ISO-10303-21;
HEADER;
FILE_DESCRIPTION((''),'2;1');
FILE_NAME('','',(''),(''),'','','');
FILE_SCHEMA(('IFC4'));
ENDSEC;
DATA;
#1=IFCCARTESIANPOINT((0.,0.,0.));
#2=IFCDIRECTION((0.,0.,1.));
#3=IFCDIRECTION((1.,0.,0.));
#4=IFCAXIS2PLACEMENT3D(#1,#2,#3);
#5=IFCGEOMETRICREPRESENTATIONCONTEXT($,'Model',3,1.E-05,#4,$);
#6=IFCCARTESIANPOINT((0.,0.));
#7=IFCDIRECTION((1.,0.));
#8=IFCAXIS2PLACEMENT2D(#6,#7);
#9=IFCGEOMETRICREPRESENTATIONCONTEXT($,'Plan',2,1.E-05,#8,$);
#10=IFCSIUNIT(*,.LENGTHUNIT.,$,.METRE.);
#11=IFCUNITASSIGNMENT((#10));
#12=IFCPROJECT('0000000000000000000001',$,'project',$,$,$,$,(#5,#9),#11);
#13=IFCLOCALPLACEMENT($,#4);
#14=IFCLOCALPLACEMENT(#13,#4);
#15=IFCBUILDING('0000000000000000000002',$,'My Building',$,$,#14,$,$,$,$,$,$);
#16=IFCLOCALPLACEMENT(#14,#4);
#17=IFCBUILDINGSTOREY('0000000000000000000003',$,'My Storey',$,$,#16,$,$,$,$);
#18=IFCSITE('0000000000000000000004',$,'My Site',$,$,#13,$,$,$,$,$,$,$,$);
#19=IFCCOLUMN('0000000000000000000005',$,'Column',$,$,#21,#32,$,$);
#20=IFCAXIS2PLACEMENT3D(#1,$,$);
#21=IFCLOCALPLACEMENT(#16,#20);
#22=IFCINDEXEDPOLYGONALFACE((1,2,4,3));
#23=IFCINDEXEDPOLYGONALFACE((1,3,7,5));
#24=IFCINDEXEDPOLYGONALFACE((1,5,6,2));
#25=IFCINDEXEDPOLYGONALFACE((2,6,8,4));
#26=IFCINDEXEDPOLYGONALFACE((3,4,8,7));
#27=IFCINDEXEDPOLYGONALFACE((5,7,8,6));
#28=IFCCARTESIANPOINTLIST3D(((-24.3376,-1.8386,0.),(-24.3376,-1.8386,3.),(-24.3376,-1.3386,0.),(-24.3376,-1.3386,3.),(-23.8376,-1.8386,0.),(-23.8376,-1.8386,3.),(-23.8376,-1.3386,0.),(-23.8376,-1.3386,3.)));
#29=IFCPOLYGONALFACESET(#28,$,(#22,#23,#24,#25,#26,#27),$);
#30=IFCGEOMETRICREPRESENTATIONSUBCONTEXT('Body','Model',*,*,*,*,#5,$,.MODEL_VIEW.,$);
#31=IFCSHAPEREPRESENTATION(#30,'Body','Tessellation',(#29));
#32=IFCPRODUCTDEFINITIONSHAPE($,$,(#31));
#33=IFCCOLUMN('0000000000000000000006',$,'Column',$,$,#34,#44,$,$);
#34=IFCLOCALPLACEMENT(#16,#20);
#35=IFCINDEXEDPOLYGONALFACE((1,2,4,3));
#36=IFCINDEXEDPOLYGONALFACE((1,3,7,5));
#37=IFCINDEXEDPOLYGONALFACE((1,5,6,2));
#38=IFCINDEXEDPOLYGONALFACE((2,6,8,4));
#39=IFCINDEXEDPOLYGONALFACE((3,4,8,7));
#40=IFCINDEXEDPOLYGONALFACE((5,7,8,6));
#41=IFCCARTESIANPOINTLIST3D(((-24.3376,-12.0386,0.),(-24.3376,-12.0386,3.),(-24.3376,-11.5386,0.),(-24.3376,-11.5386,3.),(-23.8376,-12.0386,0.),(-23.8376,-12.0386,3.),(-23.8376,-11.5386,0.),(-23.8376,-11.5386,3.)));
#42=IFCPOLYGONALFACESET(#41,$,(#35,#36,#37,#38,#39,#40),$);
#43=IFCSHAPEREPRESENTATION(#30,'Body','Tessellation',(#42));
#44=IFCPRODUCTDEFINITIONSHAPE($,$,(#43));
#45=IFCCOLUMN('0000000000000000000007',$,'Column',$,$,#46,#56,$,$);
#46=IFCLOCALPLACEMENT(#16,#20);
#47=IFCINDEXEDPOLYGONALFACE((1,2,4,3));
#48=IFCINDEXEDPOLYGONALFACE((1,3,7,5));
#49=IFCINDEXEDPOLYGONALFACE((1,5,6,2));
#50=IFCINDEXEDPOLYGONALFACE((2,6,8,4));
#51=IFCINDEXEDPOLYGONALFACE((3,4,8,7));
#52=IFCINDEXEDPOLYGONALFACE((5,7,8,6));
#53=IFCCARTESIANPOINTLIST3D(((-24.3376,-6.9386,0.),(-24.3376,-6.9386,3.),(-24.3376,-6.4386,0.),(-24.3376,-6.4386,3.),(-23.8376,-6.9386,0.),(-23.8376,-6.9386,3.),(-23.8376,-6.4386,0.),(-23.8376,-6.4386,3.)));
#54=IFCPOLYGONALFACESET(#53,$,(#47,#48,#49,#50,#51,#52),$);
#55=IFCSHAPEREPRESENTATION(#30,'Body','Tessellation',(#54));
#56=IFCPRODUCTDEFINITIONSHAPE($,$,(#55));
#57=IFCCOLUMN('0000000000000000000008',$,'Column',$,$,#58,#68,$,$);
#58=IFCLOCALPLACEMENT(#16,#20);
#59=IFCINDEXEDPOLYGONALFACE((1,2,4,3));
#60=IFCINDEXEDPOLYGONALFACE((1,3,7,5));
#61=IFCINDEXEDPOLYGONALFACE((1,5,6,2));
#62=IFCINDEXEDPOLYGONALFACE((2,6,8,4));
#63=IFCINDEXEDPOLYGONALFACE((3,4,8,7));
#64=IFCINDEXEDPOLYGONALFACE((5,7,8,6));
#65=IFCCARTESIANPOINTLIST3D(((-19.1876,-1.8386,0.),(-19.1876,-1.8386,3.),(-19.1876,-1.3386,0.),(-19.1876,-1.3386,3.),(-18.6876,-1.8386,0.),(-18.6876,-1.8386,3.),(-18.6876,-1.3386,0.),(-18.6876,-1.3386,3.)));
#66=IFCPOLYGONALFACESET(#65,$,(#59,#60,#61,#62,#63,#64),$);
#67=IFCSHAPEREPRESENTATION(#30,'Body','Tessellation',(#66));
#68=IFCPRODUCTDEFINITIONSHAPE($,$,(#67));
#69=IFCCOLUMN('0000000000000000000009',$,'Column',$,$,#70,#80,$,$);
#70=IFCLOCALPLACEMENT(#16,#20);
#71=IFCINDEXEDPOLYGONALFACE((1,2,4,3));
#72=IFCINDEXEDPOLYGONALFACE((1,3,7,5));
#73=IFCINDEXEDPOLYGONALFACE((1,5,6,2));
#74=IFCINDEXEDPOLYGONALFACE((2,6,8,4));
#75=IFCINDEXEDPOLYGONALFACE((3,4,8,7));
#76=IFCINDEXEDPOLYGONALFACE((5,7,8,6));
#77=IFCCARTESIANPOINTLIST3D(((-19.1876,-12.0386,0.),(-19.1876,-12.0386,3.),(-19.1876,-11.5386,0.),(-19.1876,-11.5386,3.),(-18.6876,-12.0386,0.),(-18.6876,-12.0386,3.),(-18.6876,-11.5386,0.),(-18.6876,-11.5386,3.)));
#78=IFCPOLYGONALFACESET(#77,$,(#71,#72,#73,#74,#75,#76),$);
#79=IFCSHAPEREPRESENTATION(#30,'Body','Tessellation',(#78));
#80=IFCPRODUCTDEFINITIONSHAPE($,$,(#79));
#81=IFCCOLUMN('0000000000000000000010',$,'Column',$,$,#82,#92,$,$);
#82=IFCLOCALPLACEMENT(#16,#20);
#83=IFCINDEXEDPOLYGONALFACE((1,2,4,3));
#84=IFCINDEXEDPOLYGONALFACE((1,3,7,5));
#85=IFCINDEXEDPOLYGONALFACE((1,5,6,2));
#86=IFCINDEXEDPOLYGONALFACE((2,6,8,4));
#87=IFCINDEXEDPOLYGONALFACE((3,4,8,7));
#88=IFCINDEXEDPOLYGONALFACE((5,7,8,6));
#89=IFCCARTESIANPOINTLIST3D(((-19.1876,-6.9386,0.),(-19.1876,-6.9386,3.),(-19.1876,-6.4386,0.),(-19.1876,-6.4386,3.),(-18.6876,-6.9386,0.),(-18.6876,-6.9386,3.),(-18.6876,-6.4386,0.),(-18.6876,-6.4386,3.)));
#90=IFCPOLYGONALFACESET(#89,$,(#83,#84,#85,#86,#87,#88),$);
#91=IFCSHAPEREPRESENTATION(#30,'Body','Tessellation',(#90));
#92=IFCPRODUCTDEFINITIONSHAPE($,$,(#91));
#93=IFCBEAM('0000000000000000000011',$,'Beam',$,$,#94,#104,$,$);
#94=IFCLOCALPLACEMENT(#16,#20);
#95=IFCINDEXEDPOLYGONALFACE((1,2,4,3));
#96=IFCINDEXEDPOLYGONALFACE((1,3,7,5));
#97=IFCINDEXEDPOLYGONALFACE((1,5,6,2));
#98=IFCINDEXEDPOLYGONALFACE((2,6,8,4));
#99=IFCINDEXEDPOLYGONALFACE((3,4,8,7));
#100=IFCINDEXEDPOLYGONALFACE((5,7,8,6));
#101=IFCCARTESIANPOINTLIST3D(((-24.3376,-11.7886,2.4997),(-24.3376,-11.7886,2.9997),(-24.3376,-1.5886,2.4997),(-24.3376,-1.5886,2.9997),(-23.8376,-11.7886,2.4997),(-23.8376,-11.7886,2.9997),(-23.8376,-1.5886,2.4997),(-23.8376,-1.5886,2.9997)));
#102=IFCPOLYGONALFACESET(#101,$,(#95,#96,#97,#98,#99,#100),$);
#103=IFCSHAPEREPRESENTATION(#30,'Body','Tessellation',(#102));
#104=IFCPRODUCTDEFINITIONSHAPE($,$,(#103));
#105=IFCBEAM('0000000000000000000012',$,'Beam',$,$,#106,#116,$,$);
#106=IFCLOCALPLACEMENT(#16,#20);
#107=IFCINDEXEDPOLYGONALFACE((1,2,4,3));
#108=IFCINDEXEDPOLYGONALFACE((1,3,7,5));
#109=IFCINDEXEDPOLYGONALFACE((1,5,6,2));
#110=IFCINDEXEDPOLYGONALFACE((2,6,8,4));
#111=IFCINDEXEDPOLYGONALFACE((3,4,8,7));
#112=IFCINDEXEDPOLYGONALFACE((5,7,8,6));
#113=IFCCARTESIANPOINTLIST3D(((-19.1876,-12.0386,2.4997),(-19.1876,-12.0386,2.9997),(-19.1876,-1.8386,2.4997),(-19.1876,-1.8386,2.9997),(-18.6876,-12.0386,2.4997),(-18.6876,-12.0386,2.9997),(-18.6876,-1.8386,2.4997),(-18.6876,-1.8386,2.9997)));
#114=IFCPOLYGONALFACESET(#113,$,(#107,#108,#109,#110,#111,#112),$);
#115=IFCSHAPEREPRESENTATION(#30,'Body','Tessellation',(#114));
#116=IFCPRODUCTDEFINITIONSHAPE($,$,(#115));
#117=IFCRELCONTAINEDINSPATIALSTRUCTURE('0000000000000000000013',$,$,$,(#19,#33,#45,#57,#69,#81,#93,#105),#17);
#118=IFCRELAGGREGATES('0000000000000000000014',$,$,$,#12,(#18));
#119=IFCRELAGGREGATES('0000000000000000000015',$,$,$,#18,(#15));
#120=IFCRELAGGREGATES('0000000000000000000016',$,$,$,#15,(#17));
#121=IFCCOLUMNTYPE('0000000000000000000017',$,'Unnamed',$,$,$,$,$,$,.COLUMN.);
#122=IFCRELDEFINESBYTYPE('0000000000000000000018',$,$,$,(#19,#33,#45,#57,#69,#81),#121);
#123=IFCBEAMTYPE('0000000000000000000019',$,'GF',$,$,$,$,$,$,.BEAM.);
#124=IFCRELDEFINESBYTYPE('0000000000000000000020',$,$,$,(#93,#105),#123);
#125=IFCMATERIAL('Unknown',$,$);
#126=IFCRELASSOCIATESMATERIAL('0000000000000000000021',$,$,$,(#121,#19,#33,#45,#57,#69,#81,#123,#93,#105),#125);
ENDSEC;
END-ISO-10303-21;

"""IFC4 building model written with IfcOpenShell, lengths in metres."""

from ifc_helpers import new_model, si_unit, frame, origin_with_axes, origin_2d_with_axis, place, context, subcontext, project, spatial, rectangle, extrude, material, material_profile, profile_set, profile_usage, type_object, element, save


model = new_model("IFC4")

# Units and contexts
model_context = context("Model", 3, precision=1e-05, world=origin_with_axes())
plan_context = context("Plan", 2, precision=1e-05, world=origin_2d_with_axis())
body_context_1 = subcontext(model_context, "Body", "Model", "MODEL_VIEW")
ifc_project = project(units=[si_unit("LENGTHUNIT", "METRE")], contexts=[model_context, plan_context])

# Site, building, storey
site_placement = place(None, origin_with_axes())
site = spatial("IfcSite", under=ifc_project, at=site_placement, Name="My Site")
building_placement = place(site_placement, origin_with_axes())
building = spatial("IfcBuilding", under=site, at=building_placement, Name="My Building")
storey_placement = place(building_placement, origin_with_axes())
storey = spatial("IfcBuildingStorey", under=building, at=storey_placement, Name="My Storey")

# Columns
ifc_material = material(Name="Unknown")
ifc_material_profile_1 = material_profile(ifc_material, rectangle(XDim=0.5, YDim=0.5))
ifc_profile_set_1 = profile_set([ifc_material_profile_1])
ifc_profile_usage_1 = profile_usage(ifc_profile_set_1, cardinal=5)
column_type = type_object("IfcColumnType", Name="Unnamed", PredefinedType="COLUMN", material=ifc_profile_set_1)
column_1_placement = place(storey_placement, frame((-24.0876, -1.5886, 0.0), z_axis=(0.0, 0.0, 1.0), x_axis=(0.0, -1.0, 0.0)))
element("IfcColumn", 1, at=column_1_placement, inside=storey, type_object=column_type, material=ifc_profile_usage_1, Name="Column", context=body_context_1, shape_type="SweptSolid", body=[
    extrude(rectangle(XDim=0.5, YDim=0.5), origin_with_axes(), (0.0, 0.0, 1.0), 3.0),
])
ifc_profile_usage_2 = profile_usage(ifc_profile_set_1, cardinal=5)
column_2_placement = place(storey_placement, frame((-24.0876, -11.7886, 0.0), z_axis=(0.0, 0.0, 1.0), x_axis=(0.0, -1.0, 0.0)))
element("IfcColumn", 2, at=column_2_placement, inside=storey, type_object=column_type, material=ifc_profile_usage_2, Name="Column", context=body_context_1, shape_type="SweptSolid", body=[
    extrude(rectangle(XDim=0.5, YDim=0.5), origin_with_axes(), (0.0, 0.0, 1.0), 3.0),
])
ifc_profile_usage_3 = profile_usage(ifc_profile_set_1, cardinal=5)
column_3_placement = place(storey_placement, frame((-24.0876, -6.6886, 0.0), z_axis=(0.0, 0.0, 1.0), x_axis=(0.0, -1.0, 0.0)))
element("IfcColumn", 3, at=column_3_placement, inside=storey, type_object=column_type, material=ifc_profile_usage_3, Name="Column", context=body_context_1, shape_type="SweptSolid", body=[
    extrude(rectangle(XDim=0.5, YDim=0.5), origin_with_axes(), (0.0, 0.0, 1.0), 3.0),
])
ifc_profile_usage_4 = profile_usage(ifc_profile_set_1, cardinal=5)
column_4_placement = place(storey_placement, frame((-18.9376, -1.5886, 0.0), z_axis=(0.0, 0.0, 1.0), x_axis=(0.0, -1.0, 0.0)))
element("IfcColumn", 4, at=column_4_placement, inside=storey, type_object=column_type, material=ifc_profile_usage_4, Name="Column", context=body_context_1, shape_type="SweptSolid", body=[
    extrude(rectangle(XDim=0.5, YDim=0.5), origin_with_axes(), (0.0, 0.0, 1.0), 3.0),
])
ifc_profile_usage_5 = profile_usage(ifc_profile_set_1, cardinal=5)
column_5_placement = place(storey_placement, frame((-18.9376, -11.7886, 0.0), z_axis=(0.0, 0.0, 1.0), x_axis=(0.0, -1.0, 0.0)))
element("IfcColumn", 5, at=column_5_placement, inside=storey, type_object=column_type, material=ifc_profile_usage_5, Name="Column", context=body_context_1, shape_type="SweptSolid", body=[
    extrude(rectangle(XDim=0.5, YDim=0.5), origin_with_axes(), (0.0, 0.0, 1.0), 3.0),
])
ifc_profile_usage_6 = profile_usage(ifc_profile_set_1, cardinal=5)
column_6_placement = place(storey_placement, frame((-18.9376, -6.6886, 0.0), z_axis=(0.0, 0.0, 1.0), x_axis=(0.0, -1.0, 0.0)))
element("IfcColumn", 6, at=column_6_placement, inside=storey, type_object=column_type, material=ifc_profile_usage_6, Name="Column", context=body_context_1, shape_type="SweptSolid", body=[
    extrude(rectangle(XDim=0.5, YDim=0.5), origin_with_axes(), (0.0, 0.0, 1.0), 3.0),
])

# Beams
ifc_material_profile_2 = material_profile(ifc_material, rectangle(XDim=0.5, YDim=0.5))
ifc_profile_set_2 = profile_set([ifc_material_profile_2])
ifc_profile_usage_7 = profile_usage(ifc_profile_set_2, cardinal=1)
beam_type = type_object("IfcBeamType", Name="GF", PredefinedType="BEAM", material=ifc_profile_set_2)
beam_1_placement = place(storey_placement, frame((-23.8376, -1.5886, 2.4997), z_axis=(-0.000001, -1.0, 0.0), x_axis=(1.0, -0.000001, 0.0)))
element("IfcBeam", 7, at=beam_1_placement, inside=storey, type_object=beam_type, material=ifc_profile_usage_7, Name="Beam", context=body_context_1, shape_type="SweptSolid", body=[
    extrude(rectangle(XDim=0.5, YDim=0.5), frame((-0.25, 0.25, 0.0), z_axis=(0.0, 0.0, 1.0), x_axis=(1.0, 0.0, 0.0)), (0.0, 0.0, 1.0), 10.2),
])
ifc_profile_usage_8 = profile_usage(ifc_profile_set_2, cardinal=1)
beam_2_placement = place(storey_placement, frame((-18.6876, -1.8386, 2.4997), z_axis=(-0.000001, -1.0, 0.0), x_axis=(1.0, -0.000001, 0.0)))
element("IfcBeam", 8, at=beam_2_placement, inside=storey, type_object=beam_type, material=ifc_profile_usage_8, Name="Beam", context=body_context_1, shape_type="SweptSolid", body=[
    extrude(rectangle(XDim=0.5, YDim=0.5), frame((-0.25, 0.25, 0.0), z_axis=(0.0, 0.0, 1.0), x_axis=(1.0, 0.0, 0.0)), (0.0, 0.0, 1.0), 10.2),
])

save(model, "model.ifc")
